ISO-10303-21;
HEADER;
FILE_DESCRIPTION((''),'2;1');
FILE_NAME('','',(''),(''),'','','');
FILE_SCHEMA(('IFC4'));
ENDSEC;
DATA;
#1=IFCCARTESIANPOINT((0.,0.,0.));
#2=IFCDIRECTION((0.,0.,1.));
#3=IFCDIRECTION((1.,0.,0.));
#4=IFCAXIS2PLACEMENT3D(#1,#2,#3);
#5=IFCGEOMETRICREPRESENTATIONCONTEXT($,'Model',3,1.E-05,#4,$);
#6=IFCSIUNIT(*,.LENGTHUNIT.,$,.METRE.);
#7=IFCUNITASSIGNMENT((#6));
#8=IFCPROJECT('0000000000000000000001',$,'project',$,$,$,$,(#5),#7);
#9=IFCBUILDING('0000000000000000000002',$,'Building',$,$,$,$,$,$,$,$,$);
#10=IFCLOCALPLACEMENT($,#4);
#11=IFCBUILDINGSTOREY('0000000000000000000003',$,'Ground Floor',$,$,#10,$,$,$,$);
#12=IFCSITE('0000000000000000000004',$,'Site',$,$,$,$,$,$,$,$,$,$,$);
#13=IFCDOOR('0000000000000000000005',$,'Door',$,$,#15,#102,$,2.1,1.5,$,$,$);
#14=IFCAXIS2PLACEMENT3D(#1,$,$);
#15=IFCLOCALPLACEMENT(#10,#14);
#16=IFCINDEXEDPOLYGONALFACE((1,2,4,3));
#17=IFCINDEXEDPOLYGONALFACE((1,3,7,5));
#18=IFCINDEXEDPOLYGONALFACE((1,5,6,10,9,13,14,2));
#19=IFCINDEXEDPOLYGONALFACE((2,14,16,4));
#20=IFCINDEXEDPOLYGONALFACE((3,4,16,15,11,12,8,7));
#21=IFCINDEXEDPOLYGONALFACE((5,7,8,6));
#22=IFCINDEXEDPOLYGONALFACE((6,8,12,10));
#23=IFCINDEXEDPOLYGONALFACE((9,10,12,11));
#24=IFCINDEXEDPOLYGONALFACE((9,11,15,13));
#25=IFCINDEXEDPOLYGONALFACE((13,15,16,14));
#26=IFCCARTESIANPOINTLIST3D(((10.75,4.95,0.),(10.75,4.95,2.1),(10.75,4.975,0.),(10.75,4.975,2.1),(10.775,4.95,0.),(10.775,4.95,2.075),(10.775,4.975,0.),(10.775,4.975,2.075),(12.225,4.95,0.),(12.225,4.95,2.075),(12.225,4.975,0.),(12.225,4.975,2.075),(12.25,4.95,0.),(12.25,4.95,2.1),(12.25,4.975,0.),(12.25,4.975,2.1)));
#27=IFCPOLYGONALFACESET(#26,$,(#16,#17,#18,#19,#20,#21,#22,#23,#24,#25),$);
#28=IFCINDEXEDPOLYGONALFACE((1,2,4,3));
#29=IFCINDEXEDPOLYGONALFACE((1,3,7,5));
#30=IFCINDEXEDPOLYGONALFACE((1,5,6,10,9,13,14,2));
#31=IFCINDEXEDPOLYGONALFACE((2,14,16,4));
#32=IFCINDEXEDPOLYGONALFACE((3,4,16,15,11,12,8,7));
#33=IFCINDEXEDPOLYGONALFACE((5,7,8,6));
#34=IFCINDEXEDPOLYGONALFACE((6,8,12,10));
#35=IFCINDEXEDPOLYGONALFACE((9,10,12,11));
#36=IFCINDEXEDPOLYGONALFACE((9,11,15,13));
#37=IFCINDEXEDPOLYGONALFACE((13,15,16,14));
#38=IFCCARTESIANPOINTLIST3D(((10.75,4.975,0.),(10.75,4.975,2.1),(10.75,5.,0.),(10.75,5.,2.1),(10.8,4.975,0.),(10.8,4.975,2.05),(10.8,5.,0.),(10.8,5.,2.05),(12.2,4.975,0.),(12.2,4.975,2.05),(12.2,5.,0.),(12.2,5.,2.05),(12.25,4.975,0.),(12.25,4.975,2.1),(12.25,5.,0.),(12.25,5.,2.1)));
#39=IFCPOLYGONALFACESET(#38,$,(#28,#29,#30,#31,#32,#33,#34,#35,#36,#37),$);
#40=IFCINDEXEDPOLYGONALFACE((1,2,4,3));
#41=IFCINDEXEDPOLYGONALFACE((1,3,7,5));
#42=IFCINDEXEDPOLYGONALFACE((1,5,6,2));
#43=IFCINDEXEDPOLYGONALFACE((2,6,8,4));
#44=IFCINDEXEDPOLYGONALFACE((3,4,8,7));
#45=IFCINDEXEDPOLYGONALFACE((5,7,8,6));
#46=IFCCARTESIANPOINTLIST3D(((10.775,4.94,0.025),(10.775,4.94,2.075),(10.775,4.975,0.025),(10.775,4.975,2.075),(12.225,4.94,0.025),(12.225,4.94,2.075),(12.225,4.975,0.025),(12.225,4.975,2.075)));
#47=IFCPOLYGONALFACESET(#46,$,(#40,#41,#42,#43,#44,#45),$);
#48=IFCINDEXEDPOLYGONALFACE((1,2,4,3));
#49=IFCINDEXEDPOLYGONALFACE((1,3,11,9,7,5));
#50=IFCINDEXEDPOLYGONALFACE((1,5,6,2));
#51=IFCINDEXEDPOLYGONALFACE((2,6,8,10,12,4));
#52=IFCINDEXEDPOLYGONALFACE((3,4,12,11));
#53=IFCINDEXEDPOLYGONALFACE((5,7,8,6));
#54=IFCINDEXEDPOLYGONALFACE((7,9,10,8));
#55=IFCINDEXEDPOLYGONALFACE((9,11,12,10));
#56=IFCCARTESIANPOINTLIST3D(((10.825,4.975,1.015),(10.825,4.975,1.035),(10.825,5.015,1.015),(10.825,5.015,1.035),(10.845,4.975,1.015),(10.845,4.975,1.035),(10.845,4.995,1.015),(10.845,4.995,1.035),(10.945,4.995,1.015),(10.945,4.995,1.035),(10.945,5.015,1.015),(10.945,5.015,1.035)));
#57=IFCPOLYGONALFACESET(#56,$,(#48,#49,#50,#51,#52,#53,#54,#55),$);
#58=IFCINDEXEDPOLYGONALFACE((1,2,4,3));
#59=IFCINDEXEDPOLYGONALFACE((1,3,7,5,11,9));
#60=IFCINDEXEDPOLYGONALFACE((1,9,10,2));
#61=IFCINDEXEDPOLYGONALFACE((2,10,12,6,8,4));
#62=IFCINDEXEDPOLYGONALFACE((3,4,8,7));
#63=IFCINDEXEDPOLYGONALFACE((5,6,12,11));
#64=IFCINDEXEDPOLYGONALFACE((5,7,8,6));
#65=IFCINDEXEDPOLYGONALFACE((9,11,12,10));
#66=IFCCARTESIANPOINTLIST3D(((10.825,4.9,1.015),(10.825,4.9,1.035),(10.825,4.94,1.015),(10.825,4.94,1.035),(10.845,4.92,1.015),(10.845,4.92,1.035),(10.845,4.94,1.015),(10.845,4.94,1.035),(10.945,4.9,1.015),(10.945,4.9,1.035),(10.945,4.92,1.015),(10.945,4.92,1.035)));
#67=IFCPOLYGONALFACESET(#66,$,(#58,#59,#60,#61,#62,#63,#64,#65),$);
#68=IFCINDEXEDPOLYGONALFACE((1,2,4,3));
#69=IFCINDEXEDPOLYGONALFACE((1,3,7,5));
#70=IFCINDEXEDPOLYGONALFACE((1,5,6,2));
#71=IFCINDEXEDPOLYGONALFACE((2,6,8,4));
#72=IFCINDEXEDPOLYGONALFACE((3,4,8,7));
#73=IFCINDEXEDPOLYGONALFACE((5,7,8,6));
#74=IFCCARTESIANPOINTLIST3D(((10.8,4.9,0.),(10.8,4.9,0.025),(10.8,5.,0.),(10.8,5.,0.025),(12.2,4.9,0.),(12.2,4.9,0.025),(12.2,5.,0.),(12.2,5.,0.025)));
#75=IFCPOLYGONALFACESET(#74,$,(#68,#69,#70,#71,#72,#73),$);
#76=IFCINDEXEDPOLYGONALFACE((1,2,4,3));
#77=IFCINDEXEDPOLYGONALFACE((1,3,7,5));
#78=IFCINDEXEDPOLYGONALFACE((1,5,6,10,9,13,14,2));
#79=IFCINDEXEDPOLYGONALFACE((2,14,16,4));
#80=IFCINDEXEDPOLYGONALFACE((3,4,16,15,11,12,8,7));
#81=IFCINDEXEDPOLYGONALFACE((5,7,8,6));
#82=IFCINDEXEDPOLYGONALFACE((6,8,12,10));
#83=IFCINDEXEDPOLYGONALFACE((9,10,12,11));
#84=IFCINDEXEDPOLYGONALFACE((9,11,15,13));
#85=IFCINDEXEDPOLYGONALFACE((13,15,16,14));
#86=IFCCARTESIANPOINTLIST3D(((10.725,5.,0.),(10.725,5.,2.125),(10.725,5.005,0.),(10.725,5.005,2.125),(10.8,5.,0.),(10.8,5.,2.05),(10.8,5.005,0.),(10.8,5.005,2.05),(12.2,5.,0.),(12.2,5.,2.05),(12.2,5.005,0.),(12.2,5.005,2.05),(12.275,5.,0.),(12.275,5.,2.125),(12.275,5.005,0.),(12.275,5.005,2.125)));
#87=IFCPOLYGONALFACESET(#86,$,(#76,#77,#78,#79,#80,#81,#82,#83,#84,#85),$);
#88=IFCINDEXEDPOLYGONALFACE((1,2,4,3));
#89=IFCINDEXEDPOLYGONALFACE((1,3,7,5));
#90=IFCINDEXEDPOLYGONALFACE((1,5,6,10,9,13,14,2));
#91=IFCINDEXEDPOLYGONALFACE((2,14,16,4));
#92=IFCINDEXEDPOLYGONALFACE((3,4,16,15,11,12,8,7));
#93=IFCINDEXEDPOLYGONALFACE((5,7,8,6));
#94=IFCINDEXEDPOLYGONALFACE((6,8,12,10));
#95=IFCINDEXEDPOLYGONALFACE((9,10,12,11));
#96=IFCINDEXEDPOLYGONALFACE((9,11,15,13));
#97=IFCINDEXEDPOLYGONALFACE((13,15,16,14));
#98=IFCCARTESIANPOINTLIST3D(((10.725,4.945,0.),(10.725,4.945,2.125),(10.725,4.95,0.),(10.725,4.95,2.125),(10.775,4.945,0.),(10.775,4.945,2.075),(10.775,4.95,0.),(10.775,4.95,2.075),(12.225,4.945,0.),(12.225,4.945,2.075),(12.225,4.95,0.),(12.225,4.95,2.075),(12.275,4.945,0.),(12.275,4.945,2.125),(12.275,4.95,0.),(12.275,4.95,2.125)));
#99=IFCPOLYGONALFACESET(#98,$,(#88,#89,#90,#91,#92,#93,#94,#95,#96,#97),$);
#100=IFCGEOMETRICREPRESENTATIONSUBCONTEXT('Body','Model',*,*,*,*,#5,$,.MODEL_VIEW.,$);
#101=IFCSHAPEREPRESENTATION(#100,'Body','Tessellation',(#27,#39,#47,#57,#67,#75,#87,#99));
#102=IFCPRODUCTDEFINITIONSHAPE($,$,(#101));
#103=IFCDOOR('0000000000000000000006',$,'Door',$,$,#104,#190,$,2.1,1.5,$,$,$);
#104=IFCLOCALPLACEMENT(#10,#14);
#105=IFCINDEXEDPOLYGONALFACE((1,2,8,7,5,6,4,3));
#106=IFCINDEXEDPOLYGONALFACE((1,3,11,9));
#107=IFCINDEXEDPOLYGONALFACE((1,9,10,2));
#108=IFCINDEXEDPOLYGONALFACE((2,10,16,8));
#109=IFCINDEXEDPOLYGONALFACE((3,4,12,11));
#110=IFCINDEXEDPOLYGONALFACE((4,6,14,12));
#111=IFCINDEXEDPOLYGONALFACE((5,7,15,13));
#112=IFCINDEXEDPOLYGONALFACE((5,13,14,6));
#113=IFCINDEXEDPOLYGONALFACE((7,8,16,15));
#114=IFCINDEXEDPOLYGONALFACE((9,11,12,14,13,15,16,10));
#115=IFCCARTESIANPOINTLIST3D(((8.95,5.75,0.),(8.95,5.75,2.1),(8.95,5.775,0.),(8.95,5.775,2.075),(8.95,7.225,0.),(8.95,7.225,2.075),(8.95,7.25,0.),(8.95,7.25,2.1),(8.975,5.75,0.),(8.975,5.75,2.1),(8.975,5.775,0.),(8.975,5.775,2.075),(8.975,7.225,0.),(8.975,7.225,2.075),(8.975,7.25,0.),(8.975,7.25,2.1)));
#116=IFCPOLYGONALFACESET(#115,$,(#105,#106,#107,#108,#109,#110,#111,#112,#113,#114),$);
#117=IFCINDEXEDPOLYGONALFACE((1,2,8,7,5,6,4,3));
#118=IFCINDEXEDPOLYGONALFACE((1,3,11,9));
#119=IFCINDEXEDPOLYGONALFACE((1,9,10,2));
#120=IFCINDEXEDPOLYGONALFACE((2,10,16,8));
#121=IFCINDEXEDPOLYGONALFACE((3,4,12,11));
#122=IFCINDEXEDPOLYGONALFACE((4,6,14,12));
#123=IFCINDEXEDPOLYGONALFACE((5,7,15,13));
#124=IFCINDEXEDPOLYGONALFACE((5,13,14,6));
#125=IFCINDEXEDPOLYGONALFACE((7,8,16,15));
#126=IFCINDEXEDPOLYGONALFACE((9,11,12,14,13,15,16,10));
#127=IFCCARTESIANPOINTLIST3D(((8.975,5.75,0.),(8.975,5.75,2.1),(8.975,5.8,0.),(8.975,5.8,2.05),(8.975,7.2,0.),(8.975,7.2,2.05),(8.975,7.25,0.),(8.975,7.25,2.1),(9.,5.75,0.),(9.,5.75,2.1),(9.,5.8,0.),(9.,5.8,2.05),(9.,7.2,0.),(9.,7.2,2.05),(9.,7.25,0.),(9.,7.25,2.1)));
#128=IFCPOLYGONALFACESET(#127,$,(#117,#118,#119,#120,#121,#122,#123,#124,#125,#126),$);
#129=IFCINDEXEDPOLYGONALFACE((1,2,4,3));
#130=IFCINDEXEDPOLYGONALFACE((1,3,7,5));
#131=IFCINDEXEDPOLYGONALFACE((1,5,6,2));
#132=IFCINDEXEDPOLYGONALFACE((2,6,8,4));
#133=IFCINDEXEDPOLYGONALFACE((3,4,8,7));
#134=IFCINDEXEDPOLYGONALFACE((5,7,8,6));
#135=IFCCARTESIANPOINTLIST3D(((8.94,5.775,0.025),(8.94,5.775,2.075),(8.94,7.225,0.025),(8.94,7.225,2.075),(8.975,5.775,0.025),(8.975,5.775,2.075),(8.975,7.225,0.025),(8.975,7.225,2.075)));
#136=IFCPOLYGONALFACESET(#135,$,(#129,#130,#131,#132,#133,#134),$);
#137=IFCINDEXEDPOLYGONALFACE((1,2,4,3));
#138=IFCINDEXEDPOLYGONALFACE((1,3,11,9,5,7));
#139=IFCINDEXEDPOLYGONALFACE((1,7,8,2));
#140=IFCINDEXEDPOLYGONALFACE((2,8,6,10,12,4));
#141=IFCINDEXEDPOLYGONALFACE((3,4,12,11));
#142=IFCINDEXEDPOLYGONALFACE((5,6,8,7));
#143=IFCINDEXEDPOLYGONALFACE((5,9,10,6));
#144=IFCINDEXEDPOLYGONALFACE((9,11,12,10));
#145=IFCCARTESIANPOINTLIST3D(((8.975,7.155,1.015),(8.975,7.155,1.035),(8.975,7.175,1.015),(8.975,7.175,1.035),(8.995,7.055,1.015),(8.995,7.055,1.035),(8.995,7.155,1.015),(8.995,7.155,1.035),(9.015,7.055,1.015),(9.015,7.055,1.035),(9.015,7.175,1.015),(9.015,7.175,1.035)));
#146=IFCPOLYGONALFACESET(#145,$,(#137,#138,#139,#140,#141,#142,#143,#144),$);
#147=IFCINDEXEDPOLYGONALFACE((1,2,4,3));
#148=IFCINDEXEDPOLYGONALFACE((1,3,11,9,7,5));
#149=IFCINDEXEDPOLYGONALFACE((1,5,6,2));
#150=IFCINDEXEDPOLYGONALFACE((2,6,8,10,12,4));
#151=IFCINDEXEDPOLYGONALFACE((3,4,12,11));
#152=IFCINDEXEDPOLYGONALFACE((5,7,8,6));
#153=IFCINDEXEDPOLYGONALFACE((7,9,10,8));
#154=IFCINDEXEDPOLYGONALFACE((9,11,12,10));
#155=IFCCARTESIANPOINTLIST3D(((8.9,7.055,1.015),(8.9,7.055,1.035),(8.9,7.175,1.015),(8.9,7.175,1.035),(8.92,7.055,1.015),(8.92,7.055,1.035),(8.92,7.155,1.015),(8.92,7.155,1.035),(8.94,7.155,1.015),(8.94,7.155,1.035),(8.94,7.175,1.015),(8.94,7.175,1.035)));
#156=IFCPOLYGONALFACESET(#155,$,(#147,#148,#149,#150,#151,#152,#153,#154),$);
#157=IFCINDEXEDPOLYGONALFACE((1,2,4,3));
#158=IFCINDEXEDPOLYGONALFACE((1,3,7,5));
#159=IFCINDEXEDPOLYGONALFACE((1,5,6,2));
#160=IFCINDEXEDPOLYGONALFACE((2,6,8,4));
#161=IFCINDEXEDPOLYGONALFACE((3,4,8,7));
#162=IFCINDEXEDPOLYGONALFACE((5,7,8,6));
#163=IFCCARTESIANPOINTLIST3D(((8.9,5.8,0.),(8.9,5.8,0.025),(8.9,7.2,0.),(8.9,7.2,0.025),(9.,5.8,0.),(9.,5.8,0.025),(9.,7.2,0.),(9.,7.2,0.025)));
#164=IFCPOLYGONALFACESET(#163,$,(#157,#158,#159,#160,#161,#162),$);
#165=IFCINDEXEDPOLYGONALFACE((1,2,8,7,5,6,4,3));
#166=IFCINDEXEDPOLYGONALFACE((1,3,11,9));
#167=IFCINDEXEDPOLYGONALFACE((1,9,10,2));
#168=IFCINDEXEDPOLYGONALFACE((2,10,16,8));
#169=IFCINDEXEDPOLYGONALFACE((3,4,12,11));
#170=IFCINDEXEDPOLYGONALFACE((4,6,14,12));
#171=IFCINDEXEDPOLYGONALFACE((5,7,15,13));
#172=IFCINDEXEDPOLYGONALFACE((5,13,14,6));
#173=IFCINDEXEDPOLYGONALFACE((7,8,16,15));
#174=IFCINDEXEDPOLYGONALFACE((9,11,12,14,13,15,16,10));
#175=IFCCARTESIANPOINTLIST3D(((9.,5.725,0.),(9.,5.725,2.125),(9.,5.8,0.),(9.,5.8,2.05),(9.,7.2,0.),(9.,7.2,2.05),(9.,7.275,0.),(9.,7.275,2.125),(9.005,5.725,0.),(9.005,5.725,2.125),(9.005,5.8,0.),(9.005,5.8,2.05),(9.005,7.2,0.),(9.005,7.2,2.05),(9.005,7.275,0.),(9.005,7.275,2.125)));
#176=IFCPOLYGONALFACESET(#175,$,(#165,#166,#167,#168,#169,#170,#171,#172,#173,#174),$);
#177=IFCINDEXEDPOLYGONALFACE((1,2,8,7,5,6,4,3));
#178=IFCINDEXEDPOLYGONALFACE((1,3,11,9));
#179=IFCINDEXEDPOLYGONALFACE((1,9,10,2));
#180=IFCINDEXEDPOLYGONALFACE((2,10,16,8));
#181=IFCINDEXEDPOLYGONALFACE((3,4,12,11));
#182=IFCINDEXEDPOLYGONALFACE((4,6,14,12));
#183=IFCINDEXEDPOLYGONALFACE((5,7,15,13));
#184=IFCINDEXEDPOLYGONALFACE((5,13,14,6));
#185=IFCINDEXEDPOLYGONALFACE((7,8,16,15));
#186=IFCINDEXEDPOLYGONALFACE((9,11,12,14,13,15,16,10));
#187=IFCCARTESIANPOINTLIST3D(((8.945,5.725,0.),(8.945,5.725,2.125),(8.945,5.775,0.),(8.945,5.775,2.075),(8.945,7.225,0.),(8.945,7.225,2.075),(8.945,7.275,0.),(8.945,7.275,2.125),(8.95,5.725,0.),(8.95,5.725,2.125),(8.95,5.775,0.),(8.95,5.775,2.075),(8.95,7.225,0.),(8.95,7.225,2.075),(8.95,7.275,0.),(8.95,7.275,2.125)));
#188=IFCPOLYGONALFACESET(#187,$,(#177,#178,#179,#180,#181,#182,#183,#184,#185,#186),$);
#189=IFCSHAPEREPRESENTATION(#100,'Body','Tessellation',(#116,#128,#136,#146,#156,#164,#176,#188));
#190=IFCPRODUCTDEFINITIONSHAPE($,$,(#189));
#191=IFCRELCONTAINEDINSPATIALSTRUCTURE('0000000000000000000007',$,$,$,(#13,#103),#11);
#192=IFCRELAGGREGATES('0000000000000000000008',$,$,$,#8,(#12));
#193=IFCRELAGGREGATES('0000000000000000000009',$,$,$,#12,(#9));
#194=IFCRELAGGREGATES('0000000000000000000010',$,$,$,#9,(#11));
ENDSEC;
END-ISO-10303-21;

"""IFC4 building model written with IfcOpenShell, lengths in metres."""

from ifc_helpers import new_model, si_unit, frame, origin_with_axes, place, context, subcontext, project, spatial, line, indexed_curve, outline, extrude, element, save


model = new_model("IFC4")

# Units and contexts
model_context = context("Model", 3, precision=1e-05, world=origin_with_axes())
body_context = subcontext(model_context, "Body", "Model", "MODEL_VIEW")
ifc_project = project(units=[si_unit("LENGTHUNIT", "METRE")], contexts=[model_context])

# Site, building, storey
site = spatial("IfcSite", under=ifc_project, Name="Site")
building = spatial("IfcBuilding", under=site, Name="Building")
storey_placement = place(None, origin_with_axes())
storey = spatial("IfcBuildingStorey", under=building, at=storey_placement, Name="Ground Floor")

# Doors
door_1_placement = place(storey_placement, frame((12.25, 5.0, 0.0), z_axis=(0.0, 0.0, 1.0), x_axis=(-1.0, 0.0, 0.0)))
element("IfcDoor", 1, at=door_1_placement, inside=storey, Name="Door", OverallHeight=2.1, OverallWidth=1.5, context=body_context, shape_type="SweptSolid", body=[
    extrude(outline(indexed_curve([(0.0, 0.0), (0.0, 2.1), (1.5, 2.1), (1.5, 0.0), (1.475, 0.0), (1.475, 2.075), (0.025, 2.075), (0.025, 0.0)], segments=[line(1, 2, 3, 4, 5, 6, 7, 8, 1)])), frame((0.0, 0.025, 0.0), z_axis=(0.0, -1.0, 0.0), x_axis=(1.0, 0.0, 0.0)), (0.0, 0.0, -1.0), 0.025),
    extrude(outline(indexed_curve([(0.0, 0.0), (0.0, 2.1), (1.5, 2.1), (1.5, 0.0), (1.45, 0.0), (1.45, 2.05), (0.05, 2.05), (0.05, 0.0)], segments=[line(1, 2, 3, 4, 5, 6, 7, 8, 1)])), frame((0.0, 0.0, 0.0), z_axis=(0.0, -1.0, 0.0), x_axis=(1.0, 0.0, 0.0)), (0.0, 0.0, -1.0), 0.025),
    extrude(outline(indexed_curve([(0.0, 0.0), (1.45, 0.0), (1.45, 0.035), (0.0, 0.035)], segments=[line(1, 2, 3, 4, 1)])), frame((0.025, 0.025, 0.025), z_axis=(0.0, 0.0, 1.0), x_axis=(1.0, 0.0, 0.0)), (0.0, 0.0, 1.0), 2.05),
    extrude(outline(indexed_curve([(0.0, 0.0), (0.0, -0.04), (-0.12, -0.04), (-0.12, -0.02), (-0.02, -0.02), (-0.02, 0.0)], segments=[line(1, 2, 3, 4, 5, 6, 1)])), frame((1.425, 0.025, 1.015), z_axis=(0.0, 0.0, 1.0), x_axis=(1.0, 0.0, 0.0)), (0.0, 0.0, 1.0), 0.02),
    extrude(outline(indexed_curve([(0.0, 0.0), (0.0, 0.04), (-0.12, 0.04), (-0.12, 0.02), (-0.02, 0.02), (-0.02, 0.0)], segments=[line(1, 2, 3, 4, 5, 6, 1)])), frame((1.425, 0.06, 1.015), z_axis=(0.0, 0.0, 1.0), x_axis=(1.0, 0.0, 0.0)), (0.0, 0.0, 1.0), 0.02),
    extrude(outline(indexed_curve([(0.0, 0.0), (1.4, 0.0), (1.4, 0.1), (0.0, 0.1)], segments=[line(1, 2, 3, 4, 1)])), frame((0.05, 0.0, 0.0), z_axis=(0.0, 0.0, 1.0), x_axis=(1.0, 0.0, 0.0)), (0.0, 0.0, 1.0), 0.025),
    extrude(outline(indexed_curve([(0.0, 0.0), (0.0, 2.125), (1.55, 2.125), (1.55, 0.0), (1.475, 0.0), (1.475, 2.05), (0.075, 2.05), (0.075, 0.0)], segments=[line(1, 2, 3, 4, 5, 6, 7, 8, 1)])), frame((-0.025, -0.005, 0.0), z_axis=(0.0, -1.0, 0.0), x_axis=(1.0, 0.0, 0.0)), (0.0, 0.0, -1.0), 0.005),
    extrude(outline(indexed_curve([(0.0, 0.0), (0.0, 2.125), (1.55, 2.125), (1.55, 0.0), (1.5, 0.0), (1.5, 2.075), (0.05, 2.075), (0.05, 0.0)], segments=[line(1, 2, 3, 4, 5, 6, 7, 8, 1)])), frame((-0.025, 0.05, 0.0), z_axis=(0.0, -1.0, 0.0), x_axis=(1.0, 0.0, 0.0)), (0.0, 0.0, -1.0), 0.005),
])
door_2_placement = place(storey_placement, frame((9.0, 5.75, 0.0), z_axis=(0.0, 0.0, 1.0), x_axis=(0.0, 1.0, 0.0)))
element("IfcDoor", 2, at=door_2_placement, inside=storey, Name="Door", OverallHeight=2.1, OverallWidth=1.5, context=body_context, shape_type="SweptSolid", body=[
    extrude(outline(indexed_curve([(0.0, 0.0), (0.0, 2.1), (1.5, 2.1), (1.5, 0.0), (1.475, 0.0), (1.475, 2.075), (0.025, 2.075), (0.025, 0.0)], segments=[line(1, 2, 3, 4, 5, 6, 7, 8, 1)])), frame((0.0, 0.025, 0.0), z_axis=(0.0, -1.0, 0.0), x_axis=(1.0, 0.0, 0.0)), (0.0, 0.0, -1.0), 0.025),
    extrude(outline(indexed_curve([(0.0, 0.0), (0.0, 2.1), (1.5, 2.1), (1.5, 0.0), (1.45, 0.0), (1.45, 2.05), (0.05, 2.05), (0.05, 0.0)], segments=[line(1, 2, 3, 4, 5, 6, 7, 8, 1)])), frame((0.0, 0.0, 0.0), z_axis=(0.0, -1.0, 0.0), x_axis=(1.0, 0.0, 0.0)), (0.0, 0.0, -1.0), 0.025),
    extrude(outline(indexed_curve([(0.0, 0.0), (1.45, 0.0), (1.45, 0.035), (0.0, 0.035)], segments=[line(1, 2, 3, 4, 1)])), frame((0.025, 0.025, 0.025), z_axis=(0.0, 0.0, 1.0), x_axis=(1.0, 0.0, 0.0)), (0.0, 0.0, 1.0), 2.05),
    extrude(outline(indexed_curve([(0.0, 0.0), (0.0, -0.04), (-0.12, -0.04), (-0.12, -0.02), (-0.02, -0.02), (-0.02, 0.0)], segments=[line(1, 2, 3, 4, 5, 6, 1)])), frame((1.425, 0.025, 1.015), z_axis=(0.0, 0.0, 1.0), x_axis=(1.0, 0.0, 0.0)), (0.0, 0.0, 1.0), 0.02),
    extrude(outline(indexed_curve([(0.0, 0.0), (0.0, 0.04), (-0.12, 0.04), (-0.12, 0.02), (-0.02, 0.02), (-0.02, 0.0)], segments=[line(1, 2, 3, 4, 5, 6, 1)])), frame((1.425, 0.06, 1.015), z_axis=(0.0, 0.0, 1.0), x_axis=(1.0, 0.0, 0.0)), (0.0, 0.0, 1.0), 0.02),
    extrude(outline(indexed_curve([(0.0, 0.0), (1.4, 0.0), (1.4, 0.1), (0.0, 0.1)], segments=[line(1, 2, 3, 4, 1)])), frame((0.05, 0.0, 0.0), z_axis=(0.0, 0.0, 1.0), x_axis=(1.0, 0.0, 0.0)), (0.0, 0.0, 1.0), 0.025),
    extrude(outline(indexed_curve([(0.0, 0.0), (0.0, 2.125), (1.55, 2.125), (1.55, 0.0), (1.475, 0.0), (1.475, 2.05), (0.075, 2.05), (0.075, 0.0)], segments=[line(1, 2, 3, 4, 5, 6, 7, 8, 1)])), frame((-0.025, -0.005, 0.0), z_axis=(0.0, -1.0, 0.0), x_axis=(1.0, 0.0, 0.0)), (0.0, 0.0, -1.0), 0.005),
    extrude(outline(indexed_curve([(0.0, 0.0), (0.0, 2.125), (1.55, 2.125), (1.55, 0.0), (1.5, 0.0), (1.5, 2.075), (0.05, 2.075), (0.05, 0.0)], segments=[line(1, 2, 3, 4, 5, 6, 7, 8, 1)])), frame((-0.025, 0.05, 0.0), z_axis=(0.0, -1.0, 0.0), x_axis=(1.0, 0.0, 0.0)), (0.0, 0.0, -1.0), 0.005),
])

save(model, "model.ifc")
